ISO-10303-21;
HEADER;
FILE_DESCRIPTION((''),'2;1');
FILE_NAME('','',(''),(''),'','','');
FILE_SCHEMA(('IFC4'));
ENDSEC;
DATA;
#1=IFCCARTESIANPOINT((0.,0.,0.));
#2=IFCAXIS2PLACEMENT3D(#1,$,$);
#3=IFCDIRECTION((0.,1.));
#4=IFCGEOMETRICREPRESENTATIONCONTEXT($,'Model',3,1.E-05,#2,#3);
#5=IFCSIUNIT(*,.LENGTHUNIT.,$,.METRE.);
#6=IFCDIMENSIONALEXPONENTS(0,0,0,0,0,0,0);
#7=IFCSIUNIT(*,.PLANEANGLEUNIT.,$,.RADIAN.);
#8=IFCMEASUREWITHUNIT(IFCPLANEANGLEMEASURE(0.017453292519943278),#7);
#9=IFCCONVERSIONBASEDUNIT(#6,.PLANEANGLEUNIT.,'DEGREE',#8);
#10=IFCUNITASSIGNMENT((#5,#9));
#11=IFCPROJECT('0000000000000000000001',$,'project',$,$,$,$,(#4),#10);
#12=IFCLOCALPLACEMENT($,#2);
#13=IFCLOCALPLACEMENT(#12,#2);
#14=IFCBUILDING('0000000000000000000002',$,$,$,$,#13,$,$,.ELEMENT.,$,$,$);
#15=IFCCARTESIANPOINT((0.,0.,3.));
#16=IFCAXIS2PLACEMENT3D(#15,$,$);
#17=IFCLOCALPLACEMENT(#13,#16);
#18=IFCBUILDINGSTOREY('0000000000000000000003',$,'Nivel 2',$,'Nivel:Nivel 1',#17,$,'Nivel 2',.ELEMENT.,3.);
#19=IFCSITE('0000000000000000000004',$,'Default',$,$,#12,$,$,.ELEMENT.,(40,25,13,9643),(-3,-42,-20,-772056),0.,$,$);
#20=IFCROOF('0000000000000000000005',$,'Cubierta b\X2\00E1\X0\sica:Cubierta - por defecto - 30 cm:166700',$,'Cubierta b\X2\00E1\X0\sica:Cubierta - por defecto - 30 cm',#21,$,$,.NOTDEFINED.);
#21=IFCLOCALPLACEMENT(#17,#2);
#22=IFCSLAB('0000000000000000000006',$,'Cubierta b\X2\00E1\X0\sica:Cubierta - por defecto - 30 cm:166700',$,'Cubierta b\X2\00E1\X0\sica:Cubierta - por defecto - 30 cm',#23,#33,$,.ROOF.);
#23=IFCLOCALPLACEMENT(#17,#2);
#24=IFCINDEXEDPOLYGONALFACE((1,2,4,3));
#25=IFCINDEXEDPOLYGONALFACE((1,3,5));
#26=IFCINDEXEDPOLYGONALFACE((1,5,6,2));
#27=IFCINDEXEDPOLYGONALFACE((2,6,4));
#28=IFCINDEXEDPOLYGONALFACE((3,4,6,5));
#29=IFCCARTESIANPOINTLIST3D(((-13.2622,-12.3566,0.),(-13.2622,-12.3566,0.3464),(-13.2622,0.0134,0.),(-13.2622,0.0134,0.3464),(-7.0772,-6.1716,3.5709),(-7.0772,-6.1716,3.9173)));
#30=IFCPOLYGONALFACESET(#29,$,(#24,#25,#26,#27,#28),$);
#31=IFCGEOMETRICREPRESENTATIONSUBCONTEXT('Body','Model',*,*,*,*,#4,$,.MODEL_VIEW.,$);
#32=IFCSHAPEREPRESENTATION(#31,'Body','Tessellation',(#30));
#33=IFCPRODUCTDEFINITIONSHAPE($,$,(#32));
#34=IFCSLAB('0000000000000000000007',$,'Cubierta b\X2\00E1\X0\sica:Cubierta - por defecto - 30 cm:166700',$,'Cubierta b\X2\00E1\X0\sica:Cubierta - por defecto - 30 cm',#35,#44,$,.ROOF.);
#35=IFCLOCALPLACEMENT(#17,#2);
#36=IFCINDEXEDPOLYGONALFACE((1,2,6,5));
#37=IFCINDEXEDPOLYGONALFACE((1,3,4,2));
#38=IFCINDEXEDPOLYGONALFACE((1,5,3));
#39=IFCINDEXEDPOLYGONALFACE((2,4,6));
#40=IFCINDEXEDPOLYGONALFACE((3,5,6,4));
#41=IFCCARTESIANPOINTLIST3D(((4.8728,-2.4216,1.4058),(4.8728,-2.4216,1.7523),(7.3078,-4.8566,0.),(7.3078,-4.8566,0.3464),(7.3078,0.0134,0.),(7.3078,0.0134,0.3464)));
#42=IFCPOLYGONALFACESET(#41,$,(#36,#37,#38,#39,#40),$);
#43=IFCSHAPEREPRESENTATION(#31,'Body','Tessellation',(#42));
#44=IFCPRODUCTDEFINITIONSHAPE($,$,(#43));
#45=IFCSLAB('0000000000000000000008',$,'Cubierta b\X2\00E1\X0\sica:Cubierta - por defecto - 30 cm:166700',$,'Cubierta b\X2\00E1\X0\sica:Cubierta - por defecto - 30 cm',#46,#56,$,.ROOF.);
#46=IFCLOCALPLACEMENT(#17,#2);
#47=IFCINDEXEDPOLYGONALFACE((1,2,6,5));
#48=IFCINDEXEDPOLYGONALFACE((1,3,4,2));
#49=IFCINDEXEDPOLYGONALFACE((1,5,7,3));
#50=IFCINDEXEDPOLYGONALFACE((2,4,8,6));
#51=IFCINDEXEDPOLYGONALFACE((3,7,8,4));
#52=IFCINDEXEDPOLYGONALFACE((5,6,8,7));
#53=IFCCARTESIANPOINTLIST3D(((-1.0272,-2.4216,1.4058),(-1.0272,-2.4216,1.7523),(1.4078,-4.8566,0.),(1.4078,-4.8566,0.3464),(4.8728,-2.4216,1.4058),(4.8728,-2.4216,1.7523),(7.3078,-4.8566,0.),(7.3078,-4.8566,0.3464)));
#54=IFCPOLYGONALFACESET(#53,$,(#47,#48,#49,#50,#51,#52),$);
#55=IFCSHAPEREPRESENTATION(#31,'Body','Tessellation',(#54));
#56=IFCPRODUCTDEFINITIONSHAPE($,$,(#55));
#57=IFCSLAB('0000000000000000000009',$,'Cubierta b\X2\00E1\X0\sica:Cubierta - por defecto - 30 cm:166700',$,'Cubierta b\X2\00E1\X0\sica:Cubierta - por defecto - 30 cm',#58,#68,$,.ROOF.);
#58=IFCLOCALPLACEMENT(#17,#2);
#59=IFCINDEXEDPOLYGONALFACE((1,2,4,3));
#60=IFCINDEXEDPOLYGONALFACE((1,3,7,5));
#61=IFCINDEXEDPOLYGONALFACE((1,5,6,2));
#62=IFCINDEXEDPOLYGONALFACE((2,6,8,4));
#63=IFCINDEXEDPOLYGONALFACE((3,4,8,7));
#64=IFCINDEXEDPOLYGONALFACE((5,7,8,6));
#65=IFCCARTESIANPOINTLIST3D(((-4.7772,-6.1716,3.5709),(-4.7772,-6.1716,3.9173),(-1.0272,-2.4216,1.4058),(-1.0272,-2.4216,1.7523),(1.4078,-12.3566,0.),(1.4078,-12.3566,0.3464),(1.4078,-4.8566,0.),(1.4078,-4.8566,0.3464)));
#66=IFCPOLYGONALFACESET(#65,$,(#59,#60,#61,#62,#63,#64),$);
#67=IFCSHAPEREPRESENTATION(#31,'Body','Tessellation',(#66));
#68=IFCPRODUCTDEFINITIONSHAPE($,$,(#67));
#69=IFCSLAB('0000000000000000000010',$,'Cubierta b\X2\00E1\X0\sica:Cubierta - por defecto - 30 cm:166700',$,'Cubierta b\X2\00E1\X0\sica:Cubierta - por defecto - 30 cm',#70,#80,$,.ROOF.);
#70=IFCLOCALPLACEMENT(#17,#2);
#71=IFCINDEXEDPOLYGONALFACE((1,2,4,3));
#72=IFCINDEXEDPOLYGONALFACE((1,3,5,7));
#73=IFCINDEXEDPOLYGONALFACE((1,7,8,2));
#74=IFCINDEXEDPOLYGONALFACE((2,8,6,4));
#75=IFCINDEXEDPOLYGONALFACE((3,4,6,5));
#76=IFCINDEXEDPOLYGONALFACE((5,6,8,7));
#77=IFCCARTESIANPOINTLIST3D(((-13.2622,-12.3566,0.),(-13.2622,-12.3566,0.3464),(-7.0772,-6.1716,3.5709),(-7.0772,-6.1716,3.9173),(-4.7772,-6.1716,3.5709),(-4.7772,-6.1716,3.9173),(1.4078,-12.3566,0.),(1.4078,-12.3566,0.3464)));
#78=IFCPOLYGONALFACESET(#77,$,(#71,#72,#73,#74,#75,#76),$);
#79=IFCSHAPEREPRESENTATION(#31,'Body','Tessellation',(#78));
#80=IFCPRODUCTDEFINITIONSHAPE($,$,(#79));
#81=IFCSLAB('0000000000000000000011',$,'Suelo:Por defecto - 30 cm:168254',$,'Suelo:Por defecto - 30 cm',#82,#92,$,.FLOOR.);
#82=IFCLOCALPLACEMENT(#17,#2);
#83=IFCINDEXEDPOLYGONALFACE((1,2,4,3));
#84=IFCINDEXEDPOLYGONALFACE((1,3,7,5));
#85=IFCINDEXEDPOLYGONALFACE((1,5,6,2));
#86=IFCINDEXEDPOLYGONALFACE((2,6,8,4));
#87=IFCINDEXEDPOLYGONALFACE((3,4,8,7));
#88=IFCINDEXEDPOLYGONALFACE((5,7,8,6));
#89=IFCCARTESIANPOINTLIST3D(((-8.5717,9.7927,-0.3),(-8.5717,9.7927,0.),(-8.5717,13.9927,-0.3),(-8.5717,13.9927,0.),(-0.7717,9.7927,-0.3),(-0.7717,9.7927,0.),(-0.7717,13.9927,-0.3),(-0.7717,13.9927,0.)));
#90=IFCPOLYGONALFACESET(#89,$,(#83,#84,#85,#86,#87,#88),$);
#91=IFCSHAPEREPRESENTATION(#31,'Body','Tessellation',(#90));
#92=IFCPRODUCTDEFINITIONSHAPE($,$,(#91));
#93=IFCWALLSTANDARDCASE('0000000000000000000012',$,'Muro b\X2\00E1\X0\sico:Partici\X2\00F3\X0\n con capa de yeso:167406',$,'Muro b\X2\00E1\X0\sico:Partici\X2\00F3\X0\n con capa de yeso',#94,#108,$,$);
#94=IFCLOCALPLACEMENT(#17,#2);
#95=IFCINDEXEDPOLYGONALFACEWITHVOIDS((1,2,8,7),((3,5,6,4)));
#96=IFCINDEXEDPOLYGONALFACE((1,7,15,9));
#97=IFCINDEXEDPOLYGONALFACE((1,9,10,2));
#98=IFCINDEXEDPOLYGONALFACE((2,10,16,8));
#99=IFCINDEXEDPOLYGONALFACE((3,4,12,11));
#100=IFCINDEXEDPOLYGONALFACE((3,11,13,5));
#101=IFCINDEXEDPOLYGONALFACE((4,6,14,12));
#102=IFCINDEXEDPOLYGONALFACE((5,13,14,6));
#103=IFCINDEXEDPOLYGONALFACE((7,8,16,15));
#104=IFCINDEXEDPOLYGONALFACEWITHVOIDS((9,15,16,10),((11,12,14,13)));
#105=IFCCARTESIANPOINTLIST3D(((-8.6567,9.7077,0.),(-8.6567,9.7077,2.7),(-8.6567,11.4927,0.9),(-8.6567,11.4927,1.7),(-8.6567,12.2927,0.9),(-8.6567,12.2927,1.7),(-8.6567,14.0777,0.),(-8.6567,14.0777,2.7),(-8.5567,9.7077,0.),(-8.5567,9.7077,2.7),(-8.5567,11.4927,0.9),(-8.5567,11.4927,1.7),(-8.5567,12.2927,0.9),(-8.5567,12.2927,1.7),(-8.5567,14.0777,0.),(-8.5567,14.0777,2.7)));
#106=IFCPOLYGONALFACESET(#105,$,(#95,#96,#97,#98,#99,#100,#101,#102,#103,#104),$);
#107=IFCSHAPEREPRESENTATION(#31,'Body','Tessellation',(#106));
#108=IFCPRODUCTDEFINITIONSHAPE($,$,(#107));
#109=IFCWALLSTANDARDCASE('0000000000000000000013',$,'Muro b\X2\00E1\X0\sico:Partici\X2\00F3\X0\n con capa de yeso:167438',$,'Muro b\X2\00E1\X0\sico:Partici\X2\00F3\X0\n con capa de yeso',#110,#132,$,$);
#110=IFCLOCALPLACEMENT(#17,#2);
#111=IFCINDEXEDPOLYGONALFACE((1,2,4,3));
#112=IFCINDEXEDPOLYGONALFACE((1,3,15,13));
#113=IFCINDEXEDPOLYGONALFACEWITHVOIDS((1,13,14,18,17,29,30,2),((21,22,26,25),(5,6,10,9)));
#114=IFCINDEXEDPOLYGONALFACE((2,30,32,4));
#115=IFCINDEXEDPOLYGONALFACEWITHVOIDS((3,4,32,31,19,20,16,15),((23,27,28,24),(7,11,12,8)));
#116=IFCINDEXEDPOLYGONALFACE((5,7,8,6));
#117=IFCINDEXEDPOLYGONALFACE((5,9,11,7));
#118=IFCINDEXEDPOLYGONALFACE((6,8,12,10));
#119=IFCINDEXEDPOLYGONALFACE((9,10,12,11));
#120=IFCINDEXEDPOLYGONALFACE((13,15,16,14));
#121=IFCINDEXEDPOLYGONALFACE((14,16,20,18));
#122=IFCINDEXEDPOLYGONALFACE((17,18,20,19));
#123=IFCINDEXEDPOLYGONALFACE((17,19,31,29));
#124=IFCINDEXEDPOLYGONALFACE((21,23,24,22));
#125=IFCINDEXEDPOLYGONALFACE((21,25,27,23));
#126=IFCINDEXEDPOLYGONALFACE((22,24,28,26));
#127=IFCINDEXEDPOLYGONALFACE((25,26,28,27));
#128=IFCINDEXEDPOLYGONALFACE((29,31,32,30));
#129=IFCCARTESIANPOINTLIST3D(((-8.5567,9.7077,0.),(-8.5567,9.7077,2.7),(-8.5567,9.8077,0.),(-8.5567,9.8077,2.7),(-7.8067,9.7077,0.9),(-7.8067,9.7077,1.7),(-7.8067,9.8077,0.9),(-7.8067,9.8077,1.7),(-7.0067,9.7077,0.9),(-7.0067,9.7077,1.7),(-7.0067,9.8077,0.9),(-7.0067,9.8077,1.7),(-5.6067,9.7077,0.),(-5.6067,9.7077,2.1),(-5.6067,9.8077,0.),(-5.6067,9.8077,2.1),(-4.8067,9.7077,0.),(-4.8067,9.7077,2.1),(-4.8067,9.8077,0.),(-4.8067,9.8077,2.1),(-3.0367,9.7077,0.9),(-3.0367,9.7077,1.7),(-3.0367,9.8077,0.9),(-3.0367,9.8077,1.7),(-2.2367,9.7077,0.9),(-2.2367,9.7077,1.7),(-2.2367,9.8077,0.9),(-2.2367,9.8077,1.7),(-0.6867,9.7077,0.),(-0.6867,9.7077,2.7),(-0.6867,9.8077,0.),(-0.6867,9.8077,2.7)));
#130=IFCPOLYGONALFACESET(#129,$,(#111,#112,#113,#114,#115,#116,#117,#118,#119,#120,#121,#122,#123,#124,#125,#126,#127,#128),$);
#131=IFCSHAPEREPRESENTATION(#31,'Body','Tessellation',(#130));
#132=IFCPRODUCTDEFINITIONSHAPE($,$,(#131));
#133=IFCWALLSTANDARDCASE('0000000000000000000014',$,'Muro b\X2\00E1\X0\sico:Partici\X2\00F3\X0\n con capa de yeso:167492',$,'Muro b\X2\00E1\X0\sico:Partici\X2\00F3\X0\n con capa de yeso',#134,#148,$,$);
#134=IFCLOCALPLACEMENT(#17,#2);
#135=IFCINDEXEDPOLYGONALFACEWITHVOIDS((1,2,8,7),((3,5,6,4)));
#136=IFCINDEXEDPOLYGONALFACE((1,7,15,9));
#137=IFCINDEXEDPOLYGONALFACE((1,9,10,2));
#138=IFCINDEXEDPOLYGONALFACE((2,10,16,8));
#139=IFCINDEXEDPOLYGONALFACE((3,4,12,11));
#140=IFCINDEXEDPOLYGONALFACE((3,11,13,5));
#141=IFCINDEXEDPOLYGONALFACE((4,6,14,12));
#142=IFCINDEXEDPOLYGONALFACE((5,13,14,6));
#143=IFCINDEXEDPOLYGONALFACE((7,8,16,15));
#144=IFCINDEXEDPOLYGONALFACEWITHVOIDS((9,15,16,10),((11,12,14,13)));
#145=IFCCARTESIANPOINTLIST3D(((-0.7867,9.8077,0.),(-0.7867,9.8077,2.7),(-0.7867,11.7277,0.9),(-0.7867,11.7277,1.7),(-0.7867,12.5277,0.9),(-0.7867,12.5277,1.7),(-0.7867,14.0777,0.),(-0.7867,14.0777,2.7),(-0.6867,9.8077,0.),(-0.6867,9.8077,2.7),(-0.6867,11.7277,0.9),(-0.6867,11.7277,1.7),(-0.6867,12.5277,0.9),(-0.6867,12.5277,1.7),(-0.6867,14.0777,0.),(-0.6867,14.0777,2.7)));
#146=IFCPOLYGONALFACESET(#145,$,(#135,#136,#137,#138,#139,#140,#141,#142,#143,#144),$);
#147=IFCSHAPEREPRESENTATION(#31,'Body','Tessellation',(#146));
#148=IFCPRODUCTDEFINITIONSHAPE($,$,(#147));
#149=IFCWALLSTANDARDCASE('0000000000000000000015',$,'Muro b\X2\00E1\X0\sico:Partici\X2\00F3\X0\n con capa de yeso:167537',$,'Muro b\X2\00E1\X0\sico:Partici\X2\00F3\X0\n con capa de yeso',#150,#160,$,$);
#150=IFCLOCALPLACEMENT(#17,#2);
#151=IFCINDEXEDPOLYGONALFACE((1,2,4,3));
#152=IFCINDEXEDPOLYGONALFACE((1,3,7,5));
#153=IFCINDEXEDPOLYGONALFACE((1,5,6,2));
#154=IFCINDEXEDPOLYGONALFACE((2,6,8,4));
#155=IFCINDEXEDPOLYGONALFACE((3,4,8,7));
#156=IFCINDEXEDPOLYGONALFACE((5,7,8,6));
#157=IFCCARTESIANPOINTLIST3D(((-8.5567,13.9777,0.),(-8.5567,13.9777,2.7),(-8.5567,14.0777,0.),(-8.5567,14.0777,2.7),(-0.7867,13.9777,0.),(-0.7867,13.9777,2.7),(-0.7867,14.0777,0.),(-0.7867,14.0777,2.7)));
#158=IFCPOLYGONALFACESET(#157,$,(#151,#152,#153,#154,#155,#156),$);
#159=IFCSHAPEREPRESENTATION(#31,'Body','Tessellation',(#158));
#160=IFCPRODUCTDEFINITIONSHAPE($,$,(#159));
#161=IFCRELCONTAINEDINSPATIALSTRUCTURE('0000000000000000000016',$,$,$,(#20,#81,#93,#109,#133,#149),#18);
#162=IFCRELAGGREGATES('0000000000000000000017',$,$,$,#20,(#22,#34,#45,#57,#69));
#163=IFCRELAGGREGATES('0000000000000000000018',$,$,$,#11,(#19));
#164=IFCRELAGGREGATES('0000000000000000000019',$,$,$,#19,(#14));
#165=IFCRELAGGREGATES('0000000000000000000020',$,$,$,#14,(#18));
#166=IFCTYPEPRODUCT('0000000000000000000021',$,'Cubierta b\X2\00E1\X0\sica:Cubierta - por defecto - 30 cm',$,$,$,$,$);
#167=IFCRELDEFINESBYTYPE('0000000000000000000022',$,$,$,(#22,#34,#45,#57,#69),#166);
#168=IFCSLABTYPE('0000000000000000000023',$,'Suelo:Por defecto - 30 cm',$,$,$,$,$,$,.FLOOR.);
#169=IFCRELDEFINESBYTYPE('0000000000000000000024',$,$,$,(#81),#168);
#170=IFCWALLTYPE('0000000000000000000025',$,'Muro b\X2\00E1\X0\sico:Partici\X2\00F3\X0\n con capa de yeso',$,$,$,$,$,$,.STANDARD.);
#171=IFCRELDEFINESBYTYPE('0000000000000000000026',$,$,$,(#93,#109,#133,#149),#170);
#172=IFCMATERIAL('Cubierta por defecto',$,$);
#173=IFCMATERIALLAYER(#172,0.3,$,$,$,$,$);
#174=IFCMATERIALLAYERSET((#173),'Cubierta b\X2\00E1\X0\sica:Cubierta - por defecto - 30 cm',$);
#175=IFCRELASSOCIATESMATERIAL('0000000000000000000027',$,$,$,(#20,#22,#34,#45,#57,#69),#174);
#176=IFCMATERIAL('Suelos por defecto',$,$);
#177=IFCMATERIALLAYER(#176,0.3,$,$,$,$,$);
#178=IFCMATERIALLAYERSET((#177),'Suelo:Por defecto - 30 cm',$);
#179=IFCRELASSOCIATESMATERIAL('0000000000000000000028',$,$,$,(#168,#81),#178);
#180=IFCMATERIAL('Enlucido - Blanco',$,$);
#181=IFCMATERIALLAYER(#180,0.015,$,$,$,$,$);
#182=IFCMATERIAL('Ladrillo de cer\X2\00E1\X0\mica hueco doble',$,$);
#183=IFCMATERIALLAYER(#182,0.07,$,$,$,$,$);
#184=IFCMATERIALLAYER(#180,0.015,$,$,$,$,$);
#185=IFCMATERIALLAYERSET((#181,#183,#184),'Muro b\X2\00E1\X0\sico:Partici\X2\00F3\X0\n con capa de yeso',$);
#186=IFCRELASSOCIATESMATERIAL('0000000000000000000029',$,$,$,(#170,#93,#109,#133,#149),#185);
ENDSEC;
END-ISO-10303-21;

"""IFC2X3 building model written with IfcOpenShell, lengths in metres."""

from ifc_helpers import new_model, entity, si_unit, converted_unit, direction, frame, frame_2d, origin, place, context, subcontext, project, spatial, polyline, rectangle, outline, extrude, material, layer, layer_set, layer_usage, type_object, element, aggregate, save


model = new_model("IFC2X3")

# Units and contexts
model_context = context("Model", 3, precision=1e-05, world=origin(), true_north=direction((0.0, 1.0)))
body_context = subcontext(model_context, "Body", "Model", "MODEL_VIEW")
ifc_project = project(units=[si_unit("LENGTHUNIT", "METRE"), converted_unit("PLANEANGLEUNIT", "DEGREE", entity("IfcPlaneAngleMeasure", 0.017453292519943278), si_unit("PLANEANGLEUNIT", "RADIAN"), dimensions=[0, 0, 0, 0, 0, 0, 0])], contexts=[model_context])

# Site, building, storey
site_placement = place(None, origin())
site = spatial("IfcSite", under=ifc_project, at=site_placement, Name="Default", CompositionType="ELEMENT", RefLatitude=(40, 25, 13, 9643), RefLongitude=(-3, -42, -20, -772056), RefElevation=0.0)
building_placement = place(site_placement, origin())
building = spatial("IfcBuilding", under=site, at=building_placement, CompositionType="ELEMENT")
storey_placement = place(building_placement, frame((0.0, 0.0, 3.0)))
storey = spatial("IfcBuildingStorey", under=building, at=storey_placement, Name="Nivel 2", ObjectType="Nivel:Nivel 1", LongName="Nivel 2", CompositionType="ELEMENT", Elevation=3.0)

# Roof, slabs
ifc_material_1 = material(Name="Cubierta por defecto")
ifc_layer_1 = layer(ifc_material_1, 0.3)
ifc_layer_set_1 = layer_set([ifc_layer_1], Name="Cubierta básica:Cubierta - por defecto - 30 cm")
roof_placement = place(storey_placement, frame((-13.2622, -12.3566, 0.0)))
roof = element("IfcRoof", 1, at=roof_placement, inside=storey, material=ifc_layer_set_1, Name="Cubierta básica:Cubierta - por defecto - 30 cm:166700", ObjectType="Cubierta básica:Cubierta - por defecto - 30 cm", ShapeType="NOTDEFINED")
type_product = type_object("IfcTypeProduct", Name="Cubierta básica:Cubierta - por defecto - 30 cm")
slab_1_placement = place(roof_placement, origin())
slab_1 = element("IfcSlab", 2, at=slab_1_placement, type_object=type_product, material=ifc_layer_set_1, Name="Cubierta básica:Cubierta - por defecto - 30 cm:166700", ObjectType="Cubierta básica:Cubierta - por defecto - 30 cm", PredefinedType="ROOF", context=body_context, shape_type="SweptSolid", body=[
    extrude(outline(polyline([(3.5709, 0.0), (-3.5709, 6.185), (-3.5709, -6.185), (3.5709, 0.0)])), frame((3.0925, 6.185, 1.7855), z_axis=(-0.5, 0.0, 0.866025), x_axis=(0.866025, 0.0, 0.5)), (0.5, 0.0, 0.866025), 0.3464),
])
slab_2_placement = place(roof_placement, origin())
slab_2 = element("IfcSlab", 3, at=slab_2_placement, type_object=type_product, material=ifc_layer_set_1, Name="Cubierta básica:Cubierta - por defecto - 30 cm:166700", ObjectType="Cubierta básica:Cubierta - por defecto - 30 cm", PredefinedType="ROOF", context=body_context, shape_type="SweptSolid", body=[
    extrude(outline(polyline([(1.4058, -2.435), (1.4058, 2.435), (-1.4058, 0.0), (1.4058, -2.435)])), frame((19.3525, 9.935, 0.7029), z_axis=(0.5, 0.0, 0.866025), x_axis=(0.866025, 0.0, -0.5)), (-0.5, 0.0, 0.866025), 0.3464),
])
slab_3_placement = place(roof_placement, origin())
slab_3 = element("IfcSlab", 4, at=slab_3_placement, type_object=type_product, material=ifc_layer_set_1, Name="Cubierta básica:Cubierta - por defecto - 30 cm:166700", ObjectType="Cubierta básica:Cubierta - por defecto - 30 cm", PredefinedType="ROOF", context=body_context, shape_type="SweptSolid", body=[
    extrude(outline(polyline([(-1.7325, -1.4058), (4.1675, -1.4058), (1.7325, 1.4058), (-4.1675, 1.4058), (-1.7325, -1.4058)])), frame((16.4025, 8.7175, 0.7029), z_axis=(0.0, -0.5, 0.866025), x_axis=(1.0, 0.0, 0.0)), (0.0, 0.5, 0.866025), 0.3464),
])
slab_4_placement = place(roof_placement, origin())
slab_4 = element("IfcSlab", 5, at=slab_4_placement, type_object=type_product, material=ifc_layer_set_1, Name="Cubierta básica:Cubierta - por defecto - 30 cm:166700", ObjectType="Cubierta básica:Cubierta - por defecto - 30 cm", PredefinedType="ROOF", context=body_context, shape_type="SweptSolid", body=[
    extrude(outline(polyline([(3.5709, -4.9675), (3.5709, 2.5325), (0.7592, 4.9675), (-3.5709, 1.2175), (3.5709, -4.9675)])), frame((11.5775, 4.9675, 1.7855), z_axis=(0.5, 0.0, 0.866025), x_axis=(0.866025, 0.0, -0.5)), (-0.5, 0.0, 0.866025), 0.3464),
])
slab_5_placement = place(roof_placement, origin())
slab_5 = element("IfcSlab", 6, at=slab_5_placement, type_object=type_product, material=ifc_layer_set_1, Name="Cubierta básica:Cubierta - por defecto - 30 cm:166700", ObjectType="Cubierta básica:Cubierta - por defecto - 30 cm", PredefinedType="ROOF", context=body_context, shape_type="SweptSolid", body=[
    extrude(outline(polyline([(-7.335, -3.5709), (7.335, -3.5709), (1.15, 3.5709), (-1.15, 3.5709), (-7.335, -3.5709)])), frame((7.335, 3.0925, 1.7855), z_axis=(0.0, -0.5, 0.866025), x_axis=(1.0, 0.0, 0.0)), (0.0, 0.5, 0.866025), 0.3464),
])
aggregate(roof, [slab_1, slab_2, slab_3, slab_4, slab_5])

# Slab
ifc_material_2 = material(Name="Suelos por defecto")
ifc_layer_2 = layer(ifc_material_2, 0.3)
ifc_layer_set_2 = layer_set([ifc_layer_2], Name="Suelo:Por defecto - 30 cm")
ifc_layer_usage_1 = layer_usage(ifc_layer_set_2, "AXIS3", "POSITIVE", 0.0)
slab_type = type_object("IfcSlabType", Name="Suelo:Por defecto - 30 cm", PredefinedType="FLOOR", material=ifc_layer_set_2)
slab_6_placement = place(storey_placement, origin())
element("IfcSlab", 7, at=slab_6_placement, inside=storey, type_object=slab_type, material=ifc_layer_usage_1, Name="Suelo:Por defecto - 30 cm:168254", ObjectType="Suelo:Por defecto - 30 cm", PredefinedType="FLOOR", context=body_context, shape_type="SweptSolid", body=[
    extrude(rectangle(XDim=4.2, YDim=7.8, at=frame_2d((0.0, 0.0), x_axis=(1.0, 0.0))), frame((-4.6717, 11.8927, 0.0), z_axis=(0.0, 0.0, -1.0), x_axis=(0.0, 1.0, 0.0)), (0.0, 0.0, 1.0), 0.3),
])

# Wall, opening
ifc_material_3 = material(Name="Enlucido - Blanco")
ifc_layer_3 = layer(ifc_material_3, 0.015)
ifc_material_4 = material(Name="Ladrillo de cerámica hueco doble")
ifc_layer_4 = layer(ifc_material_4, 0.07)
ifc_layer_5 = layer(ifc_material_3, 0.015)
ifc_layer_set_3 = layer_set([ifc_layer_3, ifc_layer_4, ifc_layer_5], Name="Muro básico:Partición con capa de yeso")
ifc_layer_usage_2 = layer_usage(ifc_layer_set_3, "AXIS2", "NEGATIVE", 0.05)
wall_type = type_object("IfcWallType", Name="Muro básico:Partición con capa de yeso", PredefinedType="STANDARD", material=ifc_layer_set_3)
wall_1_placement = place(storey_placement, frame((-8.6067, 14.0777, 0.0), z_axis=(0.0, 0.0, 1.0), x_axis=(0.0, -1.0, 0.0)))
wall_1 = element("IfcWallStandardCase", 8, at=wall_1_placement, inside=storey, type_object=wall_type, material=ifc_layer_usage_2, Name="Muro básico:Partición con capa de yeso:167406", ObjectType="Muro básico:Partición con capa de yeso", context=body_context, shape_type="SweptSolid", body=[
    extrude(rectangle(XDim=4.37, YDim=0.1, at=frame_2d((2.185, 0.0), x_axis=(-1.0, 0.0))), origin(), (0.0, 0.0, 1.0), 2.7),
])
opening_1_placement = place(wall_1_placement, frame((2.585, 0.05, 0.9)))
element("IfcOpeningElement", 9, at=opening_1_placement, cuts=wall_1, ObjectType="Opening", context=body_context, shape_type="SweptSolid", body=[
    extrude(rectangle(XDim=0.8, YDim=0.8, at=frame_2d((0.4, 0.4), x_axis=(1.0, 0.0))), frame((0.0, 0.0, 0.0), z_axis=(0.0, -1.0, 0.0), x_axis=(0.0, 0.0, 1.0)), (0.0, 0.0, 1.0), 0.1),
])

# Wall, openings
ifc_layer_usage_3 = layer_usage(ifc_layer_set_3, "AXIS2", "NEGATIVE", 0.05)
wall_2_placement = place(storey_placement, frame((-8.5567, 9.7577, 0.0)))
wall_2 = element("IfcWallStandardCase", 10, at=wall_2_placement, inside=storey, type_object=wall_type, material=ifc_layer_usage_3, Name="Muro básico:Partición con capa de yeso:167438", ObjectType="Muro básico:Partición con capa de yeso", context=body_context, shape_type="SweptSolid", body=[
    extrude(rectangle(XDim=7.87, YDim=0.1, at=frame_2d((3.935, 0.0), x_axis=(-1.0, 0.0))), origin(), (0.0, 0.0, 1.0), 2.7),
])
opening_2_placement = place(wall_2_placement, frame((3.75, 0.05, 0.0)))
element("IfcOpeningElement", 11, at=opening_2_placement, cuts=wall_2, ObjectType="Opening", context=body_context, shape_type="SweptSolid", body=[
    extrude(rectangle(XDim=2.1, YDim=0.8, at=frame_2d((1.05, 0.4), x_axis=(1.0, 0.0))), frame((0.0, 0.0, 0.0), z_axis=(0.0, -1.0, 0.0), x_axis=(0.0, 0.0, 1.0)), (0.0, 0.0, 1.0), 0.1),
])
opening_3_placement = place(wall_2_placement, frame((6.32, 0.05, 0.9)))
element("IfcOpeningElement", 12, at=opening_3_placement, cuts=wall_2, ObjectType="Opening", context=body_context, shape_type="SweptSolid", body=[
    extrude(rectangle(XDim=0.8, YDim=0.8, at=frame_2d((0.4, 0.4), x_axis=(1.0, 0.0))), frame((0.0, 0.0, 0.0), z_axis=(0.0, -1.0, 0.0), x_axis=(0.0, 0.0, 1.0)), (0.0, 0.0, 1.0), 0.1),
])
opening_4_placement = place(wall_2_placement, frame((1.55, 0.05, 0.9)))
element("IfcOpeningElement", 13, at=opening_4_placement, cuts=wall_2, ObjectType="Opening", context=body_context, shape_type="SweptSolid", body=[
    extrude(rectangle(XDim=0.8, YDim=0.8, at=frame_2d((0.4, 0.4), x_axis=(1.0, 0.0))), frame((0.0, 0.0, 0.0), z_axis=(0.0, -1.0, 0.0), x_axis=(0.0, 0.0, 1.0)), (0.0, 0.0, 1.0), 0.1),
])

# Wall, opening
ifc_layer_usage_4 = layer_usage(ifc_layer_set_3, "AXIS2", "NEGATIVE", 0.05)
wall_3_placement = place(storey_placement, frame((-0.7367, 9.8077, 0.0), z_axis=(0.0, 0.0, 1.0), x_axis=(0.0, 1.0, 0.0)))
wall_3 = element("IfcWallStandardCase", 14, at=wall_3_placement, inside=storey, type_object=wall_type, material=ifc_layer_usage_4, Name="Muro básico:Partición con capa de yeso:167492", ObjectType="Muro básico:Partición con capa de yeso", context=body_context, shape_type="SweptSolid", body=[
    extrude(rectangle(XDim=4.27, YDim=0.1, at=frame_2d((2.135, 0.0), x_axis=(-1.0, 0.0))), origin(), (0.0, 0.0, 1.0), 2.7),
])
opening_5_placement = place(wall_3_placement, frame((2.72, 0.05, 0.9)))
element("IfcOpeningElement", 15, at=opening_5_placement, cuts=wall_3, ObjectType="Opening", context=body_context, shape_type="SweptSolid", body=[
    extrude(rectangle(XDim=0.8, YDim=0.8, at=frame_2d((0.4, 0.4), x_axis=(1.0, 0.0))), frame((0.0, 0.0, 0.0), z_axis=(0.0, -1.0, 0.0), x_axis=(0.0, 0.0, 1.0)), (0.0, 0.0, 1.0), 0.1),
])

# Wall
ifc_layer_usage_5 = layer_usage(ifc_layer_set_3, "AXIS2", "NEGATIVE", 0.05)
wall_4_placement = place(storey_placement, frame((-0.7867, 14.0277, 0.0), z_axis=(0.0, 0.0, 1.0), x_axis=(-1.0, 0.0, 0.0)))
element("IfcWallStandardCase", 16, at=wall_4_placement, inside=storey, type_object=wall_type, material=ifc_layer_usage_5, Name="Muro básico:Partición con capa de yeso:167537", ObjectType="Muro básico:Partición con capa de yeso", context=body_context, shape_type="SweptSolid", body=[
    extrude(rectangle(XDim=7.77, YDim=0.1, at=frame_2d((3.885, 0.0), x_axis=(-1.0, 0.0))), origin(), (0.0, 0.0, 1.0), 2.7),
])

save(model, "model.ifc")
